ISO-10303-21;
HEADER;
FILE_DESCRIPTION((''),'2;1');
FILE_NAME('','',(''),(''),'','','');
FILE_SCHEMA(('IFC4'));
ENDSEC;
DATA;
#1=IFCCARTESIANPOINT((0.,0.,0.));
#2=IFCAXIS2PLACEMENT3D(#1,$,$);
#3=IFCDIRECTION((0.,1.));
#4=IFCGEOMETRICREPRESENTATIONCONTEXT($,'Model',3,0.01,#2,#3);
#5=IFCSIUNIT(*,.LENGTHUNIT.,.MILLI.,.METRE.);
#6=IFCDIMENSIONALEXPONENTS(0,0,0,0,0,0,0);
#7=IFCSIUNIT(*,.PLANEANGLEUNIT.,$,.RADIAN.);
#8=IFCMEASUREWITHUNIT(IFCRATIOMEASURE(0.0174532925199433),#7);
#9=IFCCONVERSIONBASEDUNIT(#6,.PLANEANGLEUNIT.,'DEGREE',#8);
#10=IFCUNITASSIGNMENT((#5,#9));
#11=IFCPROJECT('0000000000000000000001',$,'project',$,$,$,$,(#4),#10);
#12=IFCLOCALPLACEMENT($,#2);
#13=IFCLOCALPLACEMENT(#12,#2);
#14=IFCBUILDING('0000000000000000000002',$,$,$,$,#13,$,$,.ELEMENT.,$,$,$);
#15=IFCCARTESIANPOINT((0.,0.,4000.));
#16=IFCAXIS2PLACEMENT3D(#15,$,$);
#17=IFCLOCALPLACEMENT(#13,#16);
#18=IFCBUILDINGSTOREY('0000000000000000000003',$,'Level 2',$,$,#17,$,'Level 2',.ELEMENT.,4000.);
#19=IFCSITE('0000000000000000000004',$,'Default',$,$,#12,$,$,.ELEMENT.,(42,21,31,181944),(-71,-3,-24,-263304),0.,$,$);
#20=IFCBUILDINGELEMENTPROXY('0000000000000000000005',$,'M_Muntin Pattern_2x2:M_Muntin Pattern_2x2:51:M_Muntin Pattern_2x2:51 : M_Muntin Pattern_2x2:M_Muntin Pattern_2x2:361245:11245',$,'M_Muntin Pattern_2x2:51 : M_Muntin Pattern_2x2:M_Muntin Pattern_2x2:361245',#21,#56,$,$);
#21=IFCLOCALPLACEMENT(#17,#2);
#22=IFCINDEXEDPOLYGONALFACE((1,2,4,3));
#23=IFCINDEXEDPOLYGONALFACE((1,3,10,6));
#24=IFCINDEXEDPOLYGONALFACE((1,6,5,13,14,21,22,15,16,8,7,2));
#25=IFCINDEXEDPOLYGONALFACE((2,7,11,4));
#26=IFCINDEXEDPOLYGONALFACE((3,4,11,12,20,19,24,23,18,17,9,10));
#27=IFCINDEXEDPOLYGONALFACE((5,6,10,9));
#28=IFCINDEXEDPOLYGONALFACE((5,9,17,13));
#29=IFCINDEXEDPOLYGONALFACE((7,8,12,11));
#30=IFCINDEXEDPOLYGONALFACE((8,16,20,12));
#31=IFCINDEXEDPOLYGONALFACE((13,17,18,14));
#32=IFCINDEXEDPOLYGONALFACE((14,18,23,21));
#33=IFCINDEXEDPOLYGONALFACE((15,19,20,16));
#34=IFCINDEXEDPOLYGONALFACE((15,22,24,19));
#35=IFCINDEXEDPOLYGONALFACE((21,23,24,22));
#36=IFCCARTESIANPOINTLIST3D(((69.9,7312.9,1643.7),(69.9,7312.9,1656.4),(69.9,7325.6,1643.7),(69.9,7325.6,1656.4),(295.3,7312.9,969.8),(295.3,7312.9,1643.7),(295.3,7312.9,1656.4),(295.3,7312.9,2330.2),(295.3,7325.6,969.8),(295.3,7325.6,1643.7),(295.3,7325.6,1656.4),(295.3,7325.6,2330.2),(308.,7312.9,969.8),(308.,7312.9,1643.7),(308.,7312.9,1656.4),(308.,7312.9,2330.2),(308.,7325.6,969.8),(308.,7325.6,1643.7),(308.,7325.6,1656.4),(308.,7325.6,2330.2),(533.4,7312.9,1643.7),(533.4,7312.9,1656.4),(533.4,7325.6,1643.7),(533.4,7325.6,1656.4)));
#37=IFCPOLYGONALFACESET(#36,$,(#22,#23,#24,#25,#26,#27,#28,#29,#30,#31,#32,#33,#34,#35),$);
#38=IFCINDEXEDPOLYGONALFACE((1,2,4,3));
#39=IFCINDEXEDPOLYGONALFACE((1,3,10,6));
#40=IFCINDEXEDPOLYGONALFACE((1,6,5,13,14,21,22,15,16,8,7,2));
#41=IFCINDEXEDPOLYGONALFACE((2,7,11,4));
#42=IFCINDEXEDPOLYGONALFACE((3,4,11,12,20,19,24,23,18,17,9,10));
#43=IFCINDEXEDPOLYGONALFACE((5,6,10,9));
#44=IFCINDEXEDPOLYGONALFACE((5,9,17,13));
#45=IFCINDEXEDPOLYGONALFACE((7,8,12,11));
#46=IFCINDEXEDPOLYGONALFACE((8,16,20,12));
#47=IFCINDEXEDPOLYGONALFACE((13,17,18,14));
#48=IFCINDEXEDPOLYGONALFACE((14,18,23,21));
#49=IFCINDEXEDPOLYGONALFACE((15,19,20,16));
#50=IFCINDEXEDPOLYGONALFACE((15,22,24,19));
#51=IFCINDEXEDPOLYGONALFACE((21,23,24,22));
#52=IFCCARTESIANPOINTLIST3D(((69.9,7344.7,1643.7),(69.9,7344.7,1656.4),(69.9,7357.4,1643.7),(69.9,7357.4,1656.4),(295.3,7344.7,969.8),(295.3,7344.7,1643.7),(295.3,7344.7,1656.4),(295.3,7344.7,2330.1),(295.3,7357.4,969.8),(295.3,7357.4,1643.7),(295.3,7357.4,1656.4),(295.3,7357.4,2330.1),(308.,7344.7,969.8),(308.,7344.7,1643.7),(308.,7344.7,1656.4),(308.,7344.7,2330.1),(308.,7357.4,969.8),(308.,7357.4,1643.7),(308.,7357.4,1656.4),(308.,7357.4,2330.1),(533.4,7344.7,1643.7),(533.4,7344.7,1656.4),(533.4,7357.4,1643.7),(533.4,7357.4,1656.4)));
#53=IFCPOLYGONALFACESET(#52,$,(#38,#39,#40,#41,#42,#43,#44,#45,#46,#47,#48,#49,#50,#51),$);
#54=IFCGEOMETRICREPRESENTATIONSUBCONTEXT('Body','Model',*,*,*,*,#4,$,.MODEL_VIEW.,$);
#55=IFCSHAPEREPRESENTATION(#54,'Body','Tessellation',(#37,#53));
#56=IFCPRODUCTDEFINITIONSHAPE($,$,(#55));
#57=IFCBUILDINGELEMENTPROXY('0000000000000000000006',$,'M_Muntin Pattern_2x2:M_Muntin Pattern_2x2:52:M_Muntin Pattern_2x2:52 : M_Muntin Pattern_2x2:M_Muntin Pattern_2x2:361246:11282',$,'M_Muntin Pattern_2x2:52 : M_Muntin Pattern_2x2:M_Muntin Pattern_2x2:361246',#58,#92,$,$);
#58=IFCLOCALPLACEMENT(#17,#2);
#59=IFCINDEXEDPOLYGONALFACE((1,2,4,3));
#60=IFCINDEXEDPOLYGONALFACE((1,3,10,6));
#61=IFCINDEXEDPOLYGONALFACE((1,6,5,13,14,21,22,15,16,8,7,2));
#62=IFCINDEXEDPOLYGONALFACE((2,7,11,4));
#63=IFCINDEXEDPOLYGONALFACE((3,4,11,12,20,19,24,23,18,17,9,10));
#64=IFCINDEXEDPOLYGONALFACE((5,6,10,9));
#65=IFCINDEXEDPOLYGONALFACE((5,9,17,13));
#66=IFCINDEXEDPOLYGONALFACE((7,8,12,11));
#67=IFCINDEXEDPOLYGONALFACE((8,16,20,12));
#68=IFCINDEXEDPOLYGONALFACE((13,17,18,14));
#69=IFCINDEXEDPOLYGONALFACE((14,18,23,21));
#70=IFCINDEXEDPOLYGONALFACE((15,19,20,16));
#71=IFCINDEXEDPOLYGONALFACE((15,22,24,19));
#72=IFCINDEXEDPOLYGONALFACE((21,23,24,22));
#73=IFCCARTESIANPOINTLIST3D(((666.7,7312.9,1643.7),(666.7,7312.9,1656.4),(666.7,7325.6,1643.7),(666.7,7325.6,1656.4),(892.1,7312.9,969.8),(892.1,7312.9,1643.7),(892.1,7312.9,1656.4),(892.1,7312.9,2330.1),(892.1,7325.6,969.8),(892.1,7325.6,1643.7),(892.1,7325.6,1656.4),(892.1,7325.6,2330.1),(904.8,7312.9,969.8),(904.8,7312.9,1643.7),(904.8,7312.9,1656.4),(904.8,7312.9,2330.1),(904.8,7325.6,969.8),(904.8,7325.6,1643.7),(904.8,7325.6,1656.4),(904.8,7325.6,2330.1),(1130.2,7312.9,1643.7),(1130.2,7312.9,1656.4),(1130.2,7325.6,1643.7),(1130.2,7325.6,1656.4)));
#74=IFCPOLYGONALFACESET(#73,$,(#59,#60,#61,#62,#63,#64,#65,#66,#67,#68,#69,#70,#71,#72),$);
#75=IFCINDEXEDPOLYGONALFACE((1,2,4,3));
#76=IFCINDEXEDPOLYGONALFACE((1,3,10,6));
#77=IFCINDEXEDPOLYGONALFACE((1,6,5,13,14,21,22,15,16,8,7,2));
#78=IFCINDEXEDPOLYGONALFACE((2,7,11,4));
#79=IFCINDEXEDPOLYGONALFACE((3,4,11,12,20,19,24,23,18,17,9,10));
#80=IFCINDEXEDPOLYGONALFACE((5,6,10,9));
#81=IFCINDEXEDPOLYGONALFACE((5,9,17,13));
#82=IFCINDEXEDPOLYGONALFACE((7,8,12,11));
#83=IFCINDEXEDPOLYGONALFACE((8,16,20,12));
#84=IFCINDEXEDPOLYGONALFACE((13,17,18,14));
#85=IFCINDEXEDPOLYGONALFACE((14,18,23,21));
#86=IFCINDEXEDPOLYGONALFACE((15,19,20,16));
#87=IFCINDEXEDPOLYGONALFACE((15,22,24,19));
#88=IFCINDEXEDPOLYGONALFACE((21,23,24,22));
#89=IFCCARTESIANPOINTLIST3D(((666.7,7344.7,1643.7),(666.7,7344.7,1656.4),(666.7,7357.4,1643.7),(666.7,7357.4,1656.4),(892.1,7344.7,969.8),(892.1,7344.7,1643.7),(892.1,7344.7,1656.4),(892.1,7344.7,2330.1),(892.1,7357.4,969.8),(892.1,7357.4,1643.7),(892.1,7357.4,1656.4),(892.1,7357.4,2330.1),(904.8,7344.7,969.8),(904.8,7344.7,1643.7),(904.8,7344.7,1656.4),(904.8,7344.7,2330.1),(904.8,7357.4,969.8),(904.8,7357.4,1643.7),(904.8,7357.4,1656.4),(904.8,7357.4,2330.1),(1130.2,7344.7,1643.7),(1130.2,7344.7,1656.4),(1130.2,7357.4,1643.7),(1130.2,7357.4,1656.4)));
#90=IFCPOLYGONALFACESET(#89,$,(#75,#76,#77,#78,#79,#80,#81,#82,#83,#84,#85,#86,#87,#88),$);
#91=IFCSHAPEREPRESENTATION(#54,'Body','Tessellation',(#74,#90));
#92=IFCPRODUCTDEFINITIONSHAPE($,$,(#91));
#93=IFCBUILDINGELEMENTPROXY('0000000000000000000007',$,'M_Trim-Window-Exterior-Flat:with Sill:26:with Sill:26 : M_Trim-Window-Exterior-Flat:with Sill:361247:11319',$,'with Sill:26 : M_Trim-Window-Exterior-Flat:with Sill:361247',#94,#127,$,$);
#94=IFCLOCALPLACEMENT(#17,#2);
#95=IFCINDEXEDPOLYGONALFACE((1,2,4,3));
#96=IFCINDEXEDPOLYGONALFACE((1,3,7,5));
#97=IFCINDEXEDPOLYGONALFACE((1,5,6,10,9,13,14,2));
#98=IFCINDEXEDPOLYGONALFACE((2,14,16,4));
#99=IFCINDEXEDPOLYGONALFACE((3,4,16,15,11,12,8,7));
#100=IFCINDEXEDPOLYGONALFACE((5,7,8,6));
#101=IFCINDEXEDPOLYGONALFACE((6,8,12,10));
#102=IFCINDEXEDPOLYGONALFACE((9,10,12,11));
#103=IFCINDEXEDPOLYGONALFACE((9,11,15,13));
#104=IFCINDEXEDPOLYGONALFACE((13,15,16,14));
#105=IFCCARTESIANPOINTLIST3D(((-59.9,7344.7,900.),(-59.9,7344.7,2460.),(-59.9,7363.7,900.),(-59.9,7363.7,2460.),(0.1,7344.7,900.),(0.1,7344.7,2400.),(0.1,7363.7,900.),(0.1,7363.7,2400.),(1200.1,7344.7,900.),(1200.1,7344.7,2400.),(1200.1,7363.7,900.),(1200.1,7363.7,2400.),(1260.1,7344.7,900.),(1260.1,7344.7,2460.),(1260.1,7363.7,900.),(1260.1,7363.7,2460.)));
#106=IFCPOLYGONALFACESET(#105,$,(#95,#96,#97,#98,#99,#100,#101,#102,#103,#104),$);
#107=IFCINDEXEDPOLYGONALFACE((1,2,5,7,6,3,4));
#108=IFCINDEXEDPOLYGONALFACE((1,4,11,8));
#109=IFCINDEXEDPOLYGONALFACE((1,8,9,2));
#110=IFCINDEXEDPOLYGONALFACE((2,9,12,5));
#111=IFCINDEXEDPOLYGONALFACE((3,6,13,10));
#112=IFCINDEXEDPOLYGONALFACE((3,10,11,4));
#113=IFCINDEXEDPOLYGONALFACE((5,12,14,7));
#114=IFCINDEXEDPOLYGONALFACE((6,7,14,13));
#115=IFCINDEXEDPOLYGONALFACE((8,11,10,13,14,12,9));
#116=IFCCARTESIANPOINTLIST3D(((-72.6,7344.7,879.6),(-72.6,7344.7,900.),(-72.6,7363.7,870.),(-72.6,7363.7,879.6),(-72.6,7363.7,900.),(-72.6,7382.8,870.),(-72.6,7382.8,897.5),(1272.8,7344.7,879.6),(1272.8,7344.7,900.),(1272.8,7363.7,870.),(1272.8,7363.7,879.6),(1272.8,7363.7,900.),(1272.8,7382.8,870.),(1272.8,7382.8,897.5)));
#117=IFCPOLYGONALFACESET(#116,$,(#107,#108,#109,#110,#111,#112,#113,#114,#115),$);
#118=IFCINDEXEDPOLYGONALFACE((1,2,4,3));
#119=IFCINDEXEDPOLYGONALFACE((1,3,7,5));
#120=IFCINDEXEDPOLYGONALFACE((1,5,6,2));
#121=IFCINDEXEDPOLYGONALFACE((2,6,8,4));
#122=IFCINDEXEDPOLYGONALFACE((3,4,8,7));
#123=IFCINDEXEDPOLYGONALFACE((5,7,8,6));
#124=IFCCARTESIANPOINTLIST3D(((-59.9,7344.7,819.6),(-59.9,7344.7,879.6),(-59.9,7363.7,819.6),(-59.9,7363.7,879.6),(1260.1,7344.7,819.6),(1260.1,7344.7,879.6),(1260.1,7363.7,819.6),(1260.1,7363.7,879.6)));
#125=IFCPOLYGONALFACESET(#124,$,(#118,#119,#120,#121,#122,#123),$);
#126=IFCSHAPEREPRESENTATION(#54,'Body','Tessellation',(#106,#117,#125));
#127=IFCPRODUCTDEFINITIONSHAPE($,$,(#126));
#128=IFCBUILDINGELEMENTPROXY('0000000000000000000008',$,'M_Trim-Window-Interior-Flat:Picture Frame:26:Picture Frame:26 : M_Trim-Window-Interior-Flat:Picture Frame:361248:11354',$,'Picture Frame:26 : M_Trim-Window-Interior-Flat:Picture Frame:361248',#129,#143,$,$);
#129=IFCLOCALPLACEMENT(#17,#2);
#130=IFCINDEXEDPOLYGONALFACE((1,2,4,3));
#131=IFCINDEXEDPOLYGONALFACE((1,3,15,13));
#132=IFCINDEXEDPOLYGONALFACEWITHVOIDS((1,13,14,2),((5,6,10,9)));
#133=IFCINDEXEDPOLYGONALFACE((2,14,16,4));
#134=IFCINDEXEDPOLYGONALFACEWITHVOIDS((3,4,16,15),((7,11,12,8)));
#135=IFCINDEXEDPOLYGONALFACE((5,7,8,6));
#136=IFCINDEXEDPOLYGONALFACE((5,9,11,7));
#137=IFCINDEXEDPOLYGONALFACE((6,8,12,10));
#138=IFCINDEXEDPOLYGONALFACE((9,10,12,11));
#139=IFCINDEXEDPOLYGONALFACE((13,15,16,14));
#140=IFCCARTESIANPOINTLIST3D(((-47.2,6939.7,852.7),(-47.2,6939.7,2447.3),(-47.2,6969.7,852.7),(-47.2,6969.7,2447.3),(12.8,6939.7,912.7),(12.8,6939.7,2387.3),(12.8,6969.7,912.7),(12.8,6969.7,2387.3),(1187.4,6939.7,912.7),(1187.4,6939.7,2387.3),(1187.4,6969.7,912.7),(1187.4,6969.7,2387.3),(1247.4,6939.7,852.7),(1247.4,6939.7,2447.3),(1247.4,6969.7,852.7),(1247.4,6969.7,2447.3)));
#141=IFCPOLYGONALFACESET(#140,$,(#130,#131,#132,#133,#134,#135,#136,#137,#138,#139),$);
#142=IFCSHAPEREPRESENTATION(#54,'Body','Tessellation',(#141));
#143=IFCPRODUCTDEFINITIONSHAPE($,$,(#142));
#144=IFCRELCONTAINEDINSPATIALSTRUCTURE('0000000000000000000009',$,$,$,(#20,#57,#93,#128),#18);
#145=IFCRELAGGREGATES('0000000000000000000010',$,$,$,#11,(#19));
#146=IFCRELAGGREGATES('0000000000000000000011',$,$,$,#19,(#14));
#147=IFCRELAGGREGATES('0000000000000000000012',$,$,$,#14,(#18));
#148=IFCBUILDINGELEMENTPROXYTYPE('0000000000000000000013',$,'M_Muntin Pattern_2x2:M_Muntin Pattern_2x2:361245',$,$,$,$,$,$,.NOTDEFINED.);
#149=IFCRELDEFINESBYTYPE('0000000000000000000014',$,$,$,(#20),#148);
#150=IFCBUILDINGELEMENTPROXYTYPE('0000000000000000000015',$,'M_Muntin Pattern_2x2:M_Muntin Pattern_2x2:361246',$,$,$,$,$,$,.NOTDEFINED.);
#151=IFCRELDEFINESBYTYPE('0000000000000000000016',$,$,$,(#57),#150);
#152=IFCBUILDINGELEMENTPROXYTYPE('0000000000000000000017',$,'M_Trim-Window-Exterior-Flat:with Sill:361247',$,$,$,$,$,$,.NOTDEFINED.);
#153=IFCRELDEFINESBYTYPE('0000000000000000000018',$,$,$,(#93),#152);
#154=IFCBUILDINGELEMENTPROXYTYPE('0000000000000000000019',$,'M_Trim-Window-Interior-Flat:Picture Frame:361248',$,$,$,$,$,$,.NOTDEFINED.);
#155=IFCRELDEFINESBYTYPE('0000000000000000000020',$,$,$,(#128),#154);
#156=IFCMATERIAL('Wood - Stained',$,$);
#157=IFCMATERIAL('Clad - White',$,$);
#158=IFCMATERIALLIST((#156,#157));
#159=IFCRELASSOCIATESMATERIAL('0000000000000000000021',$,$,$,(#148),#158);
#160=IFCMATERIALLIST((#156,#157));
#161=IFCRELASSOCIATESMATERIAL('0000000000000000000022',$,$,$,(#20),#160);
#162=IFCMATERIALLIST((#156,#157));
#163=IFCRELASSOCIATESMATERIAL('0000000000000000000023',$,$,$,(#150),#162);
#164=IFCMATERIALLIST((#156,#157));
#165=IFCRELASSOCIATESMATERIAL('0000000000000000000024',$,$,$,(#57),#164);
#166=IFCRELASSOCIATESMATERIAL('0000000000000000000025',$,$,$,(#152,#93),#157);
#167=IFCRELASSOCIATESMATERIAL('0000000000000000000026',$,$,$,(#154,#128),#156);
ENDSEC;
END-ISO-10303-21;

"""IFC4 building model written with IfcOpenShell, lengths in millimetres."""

from ifc_helpers import new_model, entity, si_unit, converted_unit, direction, frame, origin, origin_2d_with_axis, place, context, subcontext, project, spatial, polyline, rectangle, outline, extrude, source, transform, mapped, material, material_list, type_object, type_shapes, element, save


model = new_model("IFC4")

# Units and contexts
model_context = context("Model", 3, precision=0.01, world=origin(), true_north=direction((0.0, 1.0)))
body_context = subcontext(model_context, "Body", "Model", "MODEL_VIEW")
ifc_project = project(units=[si_unit("LENGTHUNIT", "METRE", prefix="MILLI"), converted_unit("PLANEANGLEUNIT", "DEGREE", entity("IfcRatioMeasure", 0.0174532925199433), si_unit("PLANEANGLEUNIT", "RADIAN"), dimensions=[0, 0, 0, 0, 0, 0, 0])], contexts=[model_context])

# Site, building, storey
site_placement = place(None, origin())
site = spatial("IfcSite", under=ifc_project, at=site_placement, Name="Default", CompositionType="ELEMENT", RefLatitude=(42, 21, 31, 181944), RefLongitude=(-71, -3, -24, -263304), RefElevation=0.0)
building_placement = place(site_placement, origin())
building = spatial("IfcBuilding", under=site, at=building_placement, CompositionType="ELEMENT")
storey_placement = place(building_placement, frame((0.0, 0.0, 4000.0)))
storey = spatial("IfcBuildingStorey", under=building, at=storey_placement, Name="Level 2", LongName="Level 2", CompositionType="ELEMENT", Elevation=4000.0)

# Building element proxies
ifc_material_1 = material(Name="Wood - Stained")
ifc_material_2 = material(Name="Clad - White")
ifc_material_list_1 = material_list([ifc_material_1, ifc_material_2])
ifc_material_list_2 = material_list([ifc_material_1, ifc_material_2])
building_element_proxy_type_1 = type_object("IfcBuildingElementProxyType", Name="M_Muntin Pattern_2x2:M_Muntin Pattern_2x2:361245", PredefinedType="NOTDEFINED", material=ifc_material_list_2)
shared_shape_1 = source(origin(), body_context, "Body", "SweptSolid", [
    extrude(outline(polyline([(-6.4, -680.2), (6.3, -680.2), (6.3, -6.4), (231.7, -6.4), (231.7, 6.3), (6.3, 6.3), (6.3, 680.2), (-6.4, 680.2), (-6.4, 6.3), (-231.7, 6.3), (-231.7, -6.4), (-6.4, -6.4), (-6.4, -680.2)])), frame((301.6, 7312.9, 5650.0), z_axis=(0.0, 1.0, 0.0), x_axis=(1.0, 0.0, 0.0)), (0.0, 0.0, 1.0), 12.7),
    extrude(outline(polyline([(-6.4, -680.1), (6.3, -680.1), (6.3, -6.4), (231.7, -6.4), (231.7, 6.3), (6.3, 6.3), (6.3, 680.2), (-6.4, 680.2), (-6.4, 6.3), (-231.7, 6.3), (-231.7, -6.4), (-6.4, -6.4), (-6.4, -680.1)])), frame((301.6, 7344.7, 5650.0), z_axis=(0.0, 1.0, 0.0), x_axis=(1.0, 0.0, 0.0)), (0.0, 0.0, 1.0), 12.7),
])
type_shapes(building_element_proxy_type_1, [shared_shape_1])
proxy_1_placement = place(storey_placement, frame((0.0, 0.0, -4000.0)))
element("IfcBuildingElementProxy", 1, at=proxy_1_placement, inside=storey, type_object=building_element_proxy_type_1, material=ifc_material_list_1, Name="M_Muntin Pattern_2x2:M_Muntin Pattern_2x2:51:M_Muntin Pattern_2x2:51 : M_Muntin Pattern_2x2:M_Muntin Pattern_2x2:361245:11245", ObjectType="M_Muntin Pattern_2x2:51 : M_Muntin Pattern_2x2:M_Muntin Pattern_2x2:361245", context=body_context, shape_type="MappedRepresentation", body=[
    mapped(shared_shape_1, transform((0.0, 0.0, 0.0), scale=1.0)),
])
ifc_material_list_3 = material_list([ifc_material_1, ifc_material_2])
ifc_material_list_4 = material_list([ifc_material_1, ifc_material_2])
building_element_proxy_type_2 = type_object("IfcBuildingElementProxyType", Name="M_Muntin Pattern_2x2:M_Muntin Pattern_2x2:361246", PredefinedType="NOTDEFINED", material=ifc_material_list_4)
shared_shape_2 = source(origin(), body_context, "Body", "SweptSolid", [
    extrude(outline(polyline([(-680.1, 6.4), (-680.1, -6.3), (-6.4, -6.3), (-6.4, -231.7), (6.3, -231.7), (6.3, -6.3), (680.2, -6.3), (680.2, 6.4), (6.3, 6.4), (6.3, 231.7), (-6.4, 231.7), (-6.4, 6.4), (-680.1, 6.4)])), frame((898.5, 7312.9, 5650.0), z_axis=(0.0, -1.0, 0.0), x_axis=(0.0, 0.0, -1.0)), (0.0, 0.0, -1.0), 12.7),
    extrude(outline(polyline([(-680.1, 6.4), (-680.1, -6.3), (-6.4, -6.3), (-6.4, -231.7), (6.3, -231.7), (6.3, -6.3), (680.2, -6.3), (680.2, 6.4), (6.3, 6.4), (6.3, 231.7), (-6.4, 231.7), (-6.4, 6.4), (-680.1, 6.4)])), frame((898.5, 7344.7, 5650.0), z_axis=(0.0, -1.0, 0.0), x_axis=(0.0, 0.0, -1.0)), (0.0, 0.0, -1.0), 12.7),
])
type_shapes(building_element_proxy_type_2, [shared_shape_2])
proxy_2_placement = place(storey_placement, frame((0.0, 0.0, -4000.0)))
element("IfcBuildingElementProxy", 2, at=proxy_2_placement, inside=storey, type_object=building_element_proxy_type_2, material=ifc_material_list_3, Name="M_Muntin Pattern_2x2:M_Muntin Pattern_2x2:52:M_Muntin Pattern_2x2:52 : M_Muntin Pattern_2x2:M_Muntin Pattern_2x2:361246:11282", ObjectType="M_Muntin Pattern_2x2:52 : M_Muntin Pattern_2x2:M_Muntin Pattern_2x2:361246", context=body_context, shape_type="MappedRepresentation", body=[
    mapped(shared_shape_2, transform((0.0, 0.0, 0.0), scale=1.0)),
])
building_element_proxy_type_3 = type_object("IfcBuildingElementProxyType", Name="M_Trim-Window-Exterior-Flat:with Sill:361247", PredefinedType="NOTDEFINED", material=ifc_material_2)
shared_shape_3 = source(origin(), body_context, "Body", "SweptSolid", [
    extrude(outline(polyline([(-660.0, -765.0), (-600.0, -765.0), (-600.0, 735.0), (600.0, 735.0), (600.0, -765.0), (660.0, -765.0), (660.0, 795.0), (-660.0, 795.0), (-660.0, -765.0)])), frame((600.1, 7344.7, 5665.0), z_axis=(0.0, 1.0, 0.0), x_axis=(-1.0, 0.0, 0.0)), (0.0, 0.0, 1.0), 19.1),
    extrude(outline(polyline([(0.0, -15.2), (19.0, -15.2), (19.0, 12.3), (0.0, 14.8), (-19.0, 14.8), (-19.0, -5.7), (0.0, -5.7), (0.0, -15.2)])), frame((-72.6, 7363.7, 4885.2), z_axis=(1.0, 0.0, 0.0), x_axis=(0.0, 1.0, 0.0)), (0.0, 0.0, 1.0), 1345.4),
    extrude(rectangle(XDim=19.1, YDim=1320.0, at=origin_2d_with_axis()), frame((600.1, 7354.2, 4819.6), z_axis=(0.0, 0.0, 1.0), x_axis=(0.0, -1.0, 0.0)), (0.0, 0.0, 1.0), 60.0),
])
type_shapes(building_element_proxy_type_3, [shared_shape_3])
proxy_3_placement = place(storey_placement, frame((0.0, 0.0, -4000.0)))
element("IfcBuildingElementProxy", 3, at=proxy_3_placement, inside=storey, type_object=building_element_proxy_type_3, material=ifc_material_2, Name="M_Trim-Window-Exterior-Flat:with Sill:26:with Sill:26 : M_Trim-Window-Exterior-Flat:with Sill:361247:11319", ObjectType="with Sill:26 : M_Trim-Window-Exterior-Flat:with Sill:361247", context=body_context, shape_type="MappedRepresentation", body=[
    mapped(shared_shape_3, transform((0.0, 0.0, 0.0), scale=1.0)),
])
building_element_proxy_type_4 = type_object("IfcBuildingElementProxyType", Name="M_Trim-Window-Interior-Flat:Picture Frame:361248", PredefinedType="NOTDEFINED", material=ifc_material_1)
shared_shape_4 = source(origin(), body_context, "Body", "SweptSolid", [
    extrude(outline(polyline([(-647.3, -797.3), (647.3, -797.3), (647.3, 797.3), (-647.3, 797.3), (-647.3, -797.3)]), holes=[polyline([(587.3, 737.3), (587.3, -737.3), (-587.3, -737.3), (-587.3, 737.3), (587.3, 737.3)])]), frame((600.1, 6939.7, 5650.0), z_axis=(0.0, 1.0, 0.0), x_axis=(1.0, 0.0, 0.0)), (0.0, 0.0, 1.0), 30.0),
])
type_shapes(building_element_proxy_type_4, [shared_shape_4])
proxy_4_placement = place(storey_placement, frame((0.0, 0.0, -4000.0)))
element("IfcBuildingElementProxy", 4, at=proxy_4_placement, inside=storey, type_object=building_element_proxy_type_4, material=ifc_material_1, Name="M_Trim-Window-Interior-Flat:Picture Frame:26:Picture Frame:26 : M_Trim-Window-Interior-Flat:Picture Frame:361248:11354", ObjectType="Picture Frame:26 : M_Trim-Window-Interior-Flat:Picture Frame:361248", context=body_context, shape_type="MappedRepresentation", body=[
    mapped(shared_shape_4, transform((0.0, 0.0, 0.0), scale=1.0)),
])

save(model, "model.ifc")
